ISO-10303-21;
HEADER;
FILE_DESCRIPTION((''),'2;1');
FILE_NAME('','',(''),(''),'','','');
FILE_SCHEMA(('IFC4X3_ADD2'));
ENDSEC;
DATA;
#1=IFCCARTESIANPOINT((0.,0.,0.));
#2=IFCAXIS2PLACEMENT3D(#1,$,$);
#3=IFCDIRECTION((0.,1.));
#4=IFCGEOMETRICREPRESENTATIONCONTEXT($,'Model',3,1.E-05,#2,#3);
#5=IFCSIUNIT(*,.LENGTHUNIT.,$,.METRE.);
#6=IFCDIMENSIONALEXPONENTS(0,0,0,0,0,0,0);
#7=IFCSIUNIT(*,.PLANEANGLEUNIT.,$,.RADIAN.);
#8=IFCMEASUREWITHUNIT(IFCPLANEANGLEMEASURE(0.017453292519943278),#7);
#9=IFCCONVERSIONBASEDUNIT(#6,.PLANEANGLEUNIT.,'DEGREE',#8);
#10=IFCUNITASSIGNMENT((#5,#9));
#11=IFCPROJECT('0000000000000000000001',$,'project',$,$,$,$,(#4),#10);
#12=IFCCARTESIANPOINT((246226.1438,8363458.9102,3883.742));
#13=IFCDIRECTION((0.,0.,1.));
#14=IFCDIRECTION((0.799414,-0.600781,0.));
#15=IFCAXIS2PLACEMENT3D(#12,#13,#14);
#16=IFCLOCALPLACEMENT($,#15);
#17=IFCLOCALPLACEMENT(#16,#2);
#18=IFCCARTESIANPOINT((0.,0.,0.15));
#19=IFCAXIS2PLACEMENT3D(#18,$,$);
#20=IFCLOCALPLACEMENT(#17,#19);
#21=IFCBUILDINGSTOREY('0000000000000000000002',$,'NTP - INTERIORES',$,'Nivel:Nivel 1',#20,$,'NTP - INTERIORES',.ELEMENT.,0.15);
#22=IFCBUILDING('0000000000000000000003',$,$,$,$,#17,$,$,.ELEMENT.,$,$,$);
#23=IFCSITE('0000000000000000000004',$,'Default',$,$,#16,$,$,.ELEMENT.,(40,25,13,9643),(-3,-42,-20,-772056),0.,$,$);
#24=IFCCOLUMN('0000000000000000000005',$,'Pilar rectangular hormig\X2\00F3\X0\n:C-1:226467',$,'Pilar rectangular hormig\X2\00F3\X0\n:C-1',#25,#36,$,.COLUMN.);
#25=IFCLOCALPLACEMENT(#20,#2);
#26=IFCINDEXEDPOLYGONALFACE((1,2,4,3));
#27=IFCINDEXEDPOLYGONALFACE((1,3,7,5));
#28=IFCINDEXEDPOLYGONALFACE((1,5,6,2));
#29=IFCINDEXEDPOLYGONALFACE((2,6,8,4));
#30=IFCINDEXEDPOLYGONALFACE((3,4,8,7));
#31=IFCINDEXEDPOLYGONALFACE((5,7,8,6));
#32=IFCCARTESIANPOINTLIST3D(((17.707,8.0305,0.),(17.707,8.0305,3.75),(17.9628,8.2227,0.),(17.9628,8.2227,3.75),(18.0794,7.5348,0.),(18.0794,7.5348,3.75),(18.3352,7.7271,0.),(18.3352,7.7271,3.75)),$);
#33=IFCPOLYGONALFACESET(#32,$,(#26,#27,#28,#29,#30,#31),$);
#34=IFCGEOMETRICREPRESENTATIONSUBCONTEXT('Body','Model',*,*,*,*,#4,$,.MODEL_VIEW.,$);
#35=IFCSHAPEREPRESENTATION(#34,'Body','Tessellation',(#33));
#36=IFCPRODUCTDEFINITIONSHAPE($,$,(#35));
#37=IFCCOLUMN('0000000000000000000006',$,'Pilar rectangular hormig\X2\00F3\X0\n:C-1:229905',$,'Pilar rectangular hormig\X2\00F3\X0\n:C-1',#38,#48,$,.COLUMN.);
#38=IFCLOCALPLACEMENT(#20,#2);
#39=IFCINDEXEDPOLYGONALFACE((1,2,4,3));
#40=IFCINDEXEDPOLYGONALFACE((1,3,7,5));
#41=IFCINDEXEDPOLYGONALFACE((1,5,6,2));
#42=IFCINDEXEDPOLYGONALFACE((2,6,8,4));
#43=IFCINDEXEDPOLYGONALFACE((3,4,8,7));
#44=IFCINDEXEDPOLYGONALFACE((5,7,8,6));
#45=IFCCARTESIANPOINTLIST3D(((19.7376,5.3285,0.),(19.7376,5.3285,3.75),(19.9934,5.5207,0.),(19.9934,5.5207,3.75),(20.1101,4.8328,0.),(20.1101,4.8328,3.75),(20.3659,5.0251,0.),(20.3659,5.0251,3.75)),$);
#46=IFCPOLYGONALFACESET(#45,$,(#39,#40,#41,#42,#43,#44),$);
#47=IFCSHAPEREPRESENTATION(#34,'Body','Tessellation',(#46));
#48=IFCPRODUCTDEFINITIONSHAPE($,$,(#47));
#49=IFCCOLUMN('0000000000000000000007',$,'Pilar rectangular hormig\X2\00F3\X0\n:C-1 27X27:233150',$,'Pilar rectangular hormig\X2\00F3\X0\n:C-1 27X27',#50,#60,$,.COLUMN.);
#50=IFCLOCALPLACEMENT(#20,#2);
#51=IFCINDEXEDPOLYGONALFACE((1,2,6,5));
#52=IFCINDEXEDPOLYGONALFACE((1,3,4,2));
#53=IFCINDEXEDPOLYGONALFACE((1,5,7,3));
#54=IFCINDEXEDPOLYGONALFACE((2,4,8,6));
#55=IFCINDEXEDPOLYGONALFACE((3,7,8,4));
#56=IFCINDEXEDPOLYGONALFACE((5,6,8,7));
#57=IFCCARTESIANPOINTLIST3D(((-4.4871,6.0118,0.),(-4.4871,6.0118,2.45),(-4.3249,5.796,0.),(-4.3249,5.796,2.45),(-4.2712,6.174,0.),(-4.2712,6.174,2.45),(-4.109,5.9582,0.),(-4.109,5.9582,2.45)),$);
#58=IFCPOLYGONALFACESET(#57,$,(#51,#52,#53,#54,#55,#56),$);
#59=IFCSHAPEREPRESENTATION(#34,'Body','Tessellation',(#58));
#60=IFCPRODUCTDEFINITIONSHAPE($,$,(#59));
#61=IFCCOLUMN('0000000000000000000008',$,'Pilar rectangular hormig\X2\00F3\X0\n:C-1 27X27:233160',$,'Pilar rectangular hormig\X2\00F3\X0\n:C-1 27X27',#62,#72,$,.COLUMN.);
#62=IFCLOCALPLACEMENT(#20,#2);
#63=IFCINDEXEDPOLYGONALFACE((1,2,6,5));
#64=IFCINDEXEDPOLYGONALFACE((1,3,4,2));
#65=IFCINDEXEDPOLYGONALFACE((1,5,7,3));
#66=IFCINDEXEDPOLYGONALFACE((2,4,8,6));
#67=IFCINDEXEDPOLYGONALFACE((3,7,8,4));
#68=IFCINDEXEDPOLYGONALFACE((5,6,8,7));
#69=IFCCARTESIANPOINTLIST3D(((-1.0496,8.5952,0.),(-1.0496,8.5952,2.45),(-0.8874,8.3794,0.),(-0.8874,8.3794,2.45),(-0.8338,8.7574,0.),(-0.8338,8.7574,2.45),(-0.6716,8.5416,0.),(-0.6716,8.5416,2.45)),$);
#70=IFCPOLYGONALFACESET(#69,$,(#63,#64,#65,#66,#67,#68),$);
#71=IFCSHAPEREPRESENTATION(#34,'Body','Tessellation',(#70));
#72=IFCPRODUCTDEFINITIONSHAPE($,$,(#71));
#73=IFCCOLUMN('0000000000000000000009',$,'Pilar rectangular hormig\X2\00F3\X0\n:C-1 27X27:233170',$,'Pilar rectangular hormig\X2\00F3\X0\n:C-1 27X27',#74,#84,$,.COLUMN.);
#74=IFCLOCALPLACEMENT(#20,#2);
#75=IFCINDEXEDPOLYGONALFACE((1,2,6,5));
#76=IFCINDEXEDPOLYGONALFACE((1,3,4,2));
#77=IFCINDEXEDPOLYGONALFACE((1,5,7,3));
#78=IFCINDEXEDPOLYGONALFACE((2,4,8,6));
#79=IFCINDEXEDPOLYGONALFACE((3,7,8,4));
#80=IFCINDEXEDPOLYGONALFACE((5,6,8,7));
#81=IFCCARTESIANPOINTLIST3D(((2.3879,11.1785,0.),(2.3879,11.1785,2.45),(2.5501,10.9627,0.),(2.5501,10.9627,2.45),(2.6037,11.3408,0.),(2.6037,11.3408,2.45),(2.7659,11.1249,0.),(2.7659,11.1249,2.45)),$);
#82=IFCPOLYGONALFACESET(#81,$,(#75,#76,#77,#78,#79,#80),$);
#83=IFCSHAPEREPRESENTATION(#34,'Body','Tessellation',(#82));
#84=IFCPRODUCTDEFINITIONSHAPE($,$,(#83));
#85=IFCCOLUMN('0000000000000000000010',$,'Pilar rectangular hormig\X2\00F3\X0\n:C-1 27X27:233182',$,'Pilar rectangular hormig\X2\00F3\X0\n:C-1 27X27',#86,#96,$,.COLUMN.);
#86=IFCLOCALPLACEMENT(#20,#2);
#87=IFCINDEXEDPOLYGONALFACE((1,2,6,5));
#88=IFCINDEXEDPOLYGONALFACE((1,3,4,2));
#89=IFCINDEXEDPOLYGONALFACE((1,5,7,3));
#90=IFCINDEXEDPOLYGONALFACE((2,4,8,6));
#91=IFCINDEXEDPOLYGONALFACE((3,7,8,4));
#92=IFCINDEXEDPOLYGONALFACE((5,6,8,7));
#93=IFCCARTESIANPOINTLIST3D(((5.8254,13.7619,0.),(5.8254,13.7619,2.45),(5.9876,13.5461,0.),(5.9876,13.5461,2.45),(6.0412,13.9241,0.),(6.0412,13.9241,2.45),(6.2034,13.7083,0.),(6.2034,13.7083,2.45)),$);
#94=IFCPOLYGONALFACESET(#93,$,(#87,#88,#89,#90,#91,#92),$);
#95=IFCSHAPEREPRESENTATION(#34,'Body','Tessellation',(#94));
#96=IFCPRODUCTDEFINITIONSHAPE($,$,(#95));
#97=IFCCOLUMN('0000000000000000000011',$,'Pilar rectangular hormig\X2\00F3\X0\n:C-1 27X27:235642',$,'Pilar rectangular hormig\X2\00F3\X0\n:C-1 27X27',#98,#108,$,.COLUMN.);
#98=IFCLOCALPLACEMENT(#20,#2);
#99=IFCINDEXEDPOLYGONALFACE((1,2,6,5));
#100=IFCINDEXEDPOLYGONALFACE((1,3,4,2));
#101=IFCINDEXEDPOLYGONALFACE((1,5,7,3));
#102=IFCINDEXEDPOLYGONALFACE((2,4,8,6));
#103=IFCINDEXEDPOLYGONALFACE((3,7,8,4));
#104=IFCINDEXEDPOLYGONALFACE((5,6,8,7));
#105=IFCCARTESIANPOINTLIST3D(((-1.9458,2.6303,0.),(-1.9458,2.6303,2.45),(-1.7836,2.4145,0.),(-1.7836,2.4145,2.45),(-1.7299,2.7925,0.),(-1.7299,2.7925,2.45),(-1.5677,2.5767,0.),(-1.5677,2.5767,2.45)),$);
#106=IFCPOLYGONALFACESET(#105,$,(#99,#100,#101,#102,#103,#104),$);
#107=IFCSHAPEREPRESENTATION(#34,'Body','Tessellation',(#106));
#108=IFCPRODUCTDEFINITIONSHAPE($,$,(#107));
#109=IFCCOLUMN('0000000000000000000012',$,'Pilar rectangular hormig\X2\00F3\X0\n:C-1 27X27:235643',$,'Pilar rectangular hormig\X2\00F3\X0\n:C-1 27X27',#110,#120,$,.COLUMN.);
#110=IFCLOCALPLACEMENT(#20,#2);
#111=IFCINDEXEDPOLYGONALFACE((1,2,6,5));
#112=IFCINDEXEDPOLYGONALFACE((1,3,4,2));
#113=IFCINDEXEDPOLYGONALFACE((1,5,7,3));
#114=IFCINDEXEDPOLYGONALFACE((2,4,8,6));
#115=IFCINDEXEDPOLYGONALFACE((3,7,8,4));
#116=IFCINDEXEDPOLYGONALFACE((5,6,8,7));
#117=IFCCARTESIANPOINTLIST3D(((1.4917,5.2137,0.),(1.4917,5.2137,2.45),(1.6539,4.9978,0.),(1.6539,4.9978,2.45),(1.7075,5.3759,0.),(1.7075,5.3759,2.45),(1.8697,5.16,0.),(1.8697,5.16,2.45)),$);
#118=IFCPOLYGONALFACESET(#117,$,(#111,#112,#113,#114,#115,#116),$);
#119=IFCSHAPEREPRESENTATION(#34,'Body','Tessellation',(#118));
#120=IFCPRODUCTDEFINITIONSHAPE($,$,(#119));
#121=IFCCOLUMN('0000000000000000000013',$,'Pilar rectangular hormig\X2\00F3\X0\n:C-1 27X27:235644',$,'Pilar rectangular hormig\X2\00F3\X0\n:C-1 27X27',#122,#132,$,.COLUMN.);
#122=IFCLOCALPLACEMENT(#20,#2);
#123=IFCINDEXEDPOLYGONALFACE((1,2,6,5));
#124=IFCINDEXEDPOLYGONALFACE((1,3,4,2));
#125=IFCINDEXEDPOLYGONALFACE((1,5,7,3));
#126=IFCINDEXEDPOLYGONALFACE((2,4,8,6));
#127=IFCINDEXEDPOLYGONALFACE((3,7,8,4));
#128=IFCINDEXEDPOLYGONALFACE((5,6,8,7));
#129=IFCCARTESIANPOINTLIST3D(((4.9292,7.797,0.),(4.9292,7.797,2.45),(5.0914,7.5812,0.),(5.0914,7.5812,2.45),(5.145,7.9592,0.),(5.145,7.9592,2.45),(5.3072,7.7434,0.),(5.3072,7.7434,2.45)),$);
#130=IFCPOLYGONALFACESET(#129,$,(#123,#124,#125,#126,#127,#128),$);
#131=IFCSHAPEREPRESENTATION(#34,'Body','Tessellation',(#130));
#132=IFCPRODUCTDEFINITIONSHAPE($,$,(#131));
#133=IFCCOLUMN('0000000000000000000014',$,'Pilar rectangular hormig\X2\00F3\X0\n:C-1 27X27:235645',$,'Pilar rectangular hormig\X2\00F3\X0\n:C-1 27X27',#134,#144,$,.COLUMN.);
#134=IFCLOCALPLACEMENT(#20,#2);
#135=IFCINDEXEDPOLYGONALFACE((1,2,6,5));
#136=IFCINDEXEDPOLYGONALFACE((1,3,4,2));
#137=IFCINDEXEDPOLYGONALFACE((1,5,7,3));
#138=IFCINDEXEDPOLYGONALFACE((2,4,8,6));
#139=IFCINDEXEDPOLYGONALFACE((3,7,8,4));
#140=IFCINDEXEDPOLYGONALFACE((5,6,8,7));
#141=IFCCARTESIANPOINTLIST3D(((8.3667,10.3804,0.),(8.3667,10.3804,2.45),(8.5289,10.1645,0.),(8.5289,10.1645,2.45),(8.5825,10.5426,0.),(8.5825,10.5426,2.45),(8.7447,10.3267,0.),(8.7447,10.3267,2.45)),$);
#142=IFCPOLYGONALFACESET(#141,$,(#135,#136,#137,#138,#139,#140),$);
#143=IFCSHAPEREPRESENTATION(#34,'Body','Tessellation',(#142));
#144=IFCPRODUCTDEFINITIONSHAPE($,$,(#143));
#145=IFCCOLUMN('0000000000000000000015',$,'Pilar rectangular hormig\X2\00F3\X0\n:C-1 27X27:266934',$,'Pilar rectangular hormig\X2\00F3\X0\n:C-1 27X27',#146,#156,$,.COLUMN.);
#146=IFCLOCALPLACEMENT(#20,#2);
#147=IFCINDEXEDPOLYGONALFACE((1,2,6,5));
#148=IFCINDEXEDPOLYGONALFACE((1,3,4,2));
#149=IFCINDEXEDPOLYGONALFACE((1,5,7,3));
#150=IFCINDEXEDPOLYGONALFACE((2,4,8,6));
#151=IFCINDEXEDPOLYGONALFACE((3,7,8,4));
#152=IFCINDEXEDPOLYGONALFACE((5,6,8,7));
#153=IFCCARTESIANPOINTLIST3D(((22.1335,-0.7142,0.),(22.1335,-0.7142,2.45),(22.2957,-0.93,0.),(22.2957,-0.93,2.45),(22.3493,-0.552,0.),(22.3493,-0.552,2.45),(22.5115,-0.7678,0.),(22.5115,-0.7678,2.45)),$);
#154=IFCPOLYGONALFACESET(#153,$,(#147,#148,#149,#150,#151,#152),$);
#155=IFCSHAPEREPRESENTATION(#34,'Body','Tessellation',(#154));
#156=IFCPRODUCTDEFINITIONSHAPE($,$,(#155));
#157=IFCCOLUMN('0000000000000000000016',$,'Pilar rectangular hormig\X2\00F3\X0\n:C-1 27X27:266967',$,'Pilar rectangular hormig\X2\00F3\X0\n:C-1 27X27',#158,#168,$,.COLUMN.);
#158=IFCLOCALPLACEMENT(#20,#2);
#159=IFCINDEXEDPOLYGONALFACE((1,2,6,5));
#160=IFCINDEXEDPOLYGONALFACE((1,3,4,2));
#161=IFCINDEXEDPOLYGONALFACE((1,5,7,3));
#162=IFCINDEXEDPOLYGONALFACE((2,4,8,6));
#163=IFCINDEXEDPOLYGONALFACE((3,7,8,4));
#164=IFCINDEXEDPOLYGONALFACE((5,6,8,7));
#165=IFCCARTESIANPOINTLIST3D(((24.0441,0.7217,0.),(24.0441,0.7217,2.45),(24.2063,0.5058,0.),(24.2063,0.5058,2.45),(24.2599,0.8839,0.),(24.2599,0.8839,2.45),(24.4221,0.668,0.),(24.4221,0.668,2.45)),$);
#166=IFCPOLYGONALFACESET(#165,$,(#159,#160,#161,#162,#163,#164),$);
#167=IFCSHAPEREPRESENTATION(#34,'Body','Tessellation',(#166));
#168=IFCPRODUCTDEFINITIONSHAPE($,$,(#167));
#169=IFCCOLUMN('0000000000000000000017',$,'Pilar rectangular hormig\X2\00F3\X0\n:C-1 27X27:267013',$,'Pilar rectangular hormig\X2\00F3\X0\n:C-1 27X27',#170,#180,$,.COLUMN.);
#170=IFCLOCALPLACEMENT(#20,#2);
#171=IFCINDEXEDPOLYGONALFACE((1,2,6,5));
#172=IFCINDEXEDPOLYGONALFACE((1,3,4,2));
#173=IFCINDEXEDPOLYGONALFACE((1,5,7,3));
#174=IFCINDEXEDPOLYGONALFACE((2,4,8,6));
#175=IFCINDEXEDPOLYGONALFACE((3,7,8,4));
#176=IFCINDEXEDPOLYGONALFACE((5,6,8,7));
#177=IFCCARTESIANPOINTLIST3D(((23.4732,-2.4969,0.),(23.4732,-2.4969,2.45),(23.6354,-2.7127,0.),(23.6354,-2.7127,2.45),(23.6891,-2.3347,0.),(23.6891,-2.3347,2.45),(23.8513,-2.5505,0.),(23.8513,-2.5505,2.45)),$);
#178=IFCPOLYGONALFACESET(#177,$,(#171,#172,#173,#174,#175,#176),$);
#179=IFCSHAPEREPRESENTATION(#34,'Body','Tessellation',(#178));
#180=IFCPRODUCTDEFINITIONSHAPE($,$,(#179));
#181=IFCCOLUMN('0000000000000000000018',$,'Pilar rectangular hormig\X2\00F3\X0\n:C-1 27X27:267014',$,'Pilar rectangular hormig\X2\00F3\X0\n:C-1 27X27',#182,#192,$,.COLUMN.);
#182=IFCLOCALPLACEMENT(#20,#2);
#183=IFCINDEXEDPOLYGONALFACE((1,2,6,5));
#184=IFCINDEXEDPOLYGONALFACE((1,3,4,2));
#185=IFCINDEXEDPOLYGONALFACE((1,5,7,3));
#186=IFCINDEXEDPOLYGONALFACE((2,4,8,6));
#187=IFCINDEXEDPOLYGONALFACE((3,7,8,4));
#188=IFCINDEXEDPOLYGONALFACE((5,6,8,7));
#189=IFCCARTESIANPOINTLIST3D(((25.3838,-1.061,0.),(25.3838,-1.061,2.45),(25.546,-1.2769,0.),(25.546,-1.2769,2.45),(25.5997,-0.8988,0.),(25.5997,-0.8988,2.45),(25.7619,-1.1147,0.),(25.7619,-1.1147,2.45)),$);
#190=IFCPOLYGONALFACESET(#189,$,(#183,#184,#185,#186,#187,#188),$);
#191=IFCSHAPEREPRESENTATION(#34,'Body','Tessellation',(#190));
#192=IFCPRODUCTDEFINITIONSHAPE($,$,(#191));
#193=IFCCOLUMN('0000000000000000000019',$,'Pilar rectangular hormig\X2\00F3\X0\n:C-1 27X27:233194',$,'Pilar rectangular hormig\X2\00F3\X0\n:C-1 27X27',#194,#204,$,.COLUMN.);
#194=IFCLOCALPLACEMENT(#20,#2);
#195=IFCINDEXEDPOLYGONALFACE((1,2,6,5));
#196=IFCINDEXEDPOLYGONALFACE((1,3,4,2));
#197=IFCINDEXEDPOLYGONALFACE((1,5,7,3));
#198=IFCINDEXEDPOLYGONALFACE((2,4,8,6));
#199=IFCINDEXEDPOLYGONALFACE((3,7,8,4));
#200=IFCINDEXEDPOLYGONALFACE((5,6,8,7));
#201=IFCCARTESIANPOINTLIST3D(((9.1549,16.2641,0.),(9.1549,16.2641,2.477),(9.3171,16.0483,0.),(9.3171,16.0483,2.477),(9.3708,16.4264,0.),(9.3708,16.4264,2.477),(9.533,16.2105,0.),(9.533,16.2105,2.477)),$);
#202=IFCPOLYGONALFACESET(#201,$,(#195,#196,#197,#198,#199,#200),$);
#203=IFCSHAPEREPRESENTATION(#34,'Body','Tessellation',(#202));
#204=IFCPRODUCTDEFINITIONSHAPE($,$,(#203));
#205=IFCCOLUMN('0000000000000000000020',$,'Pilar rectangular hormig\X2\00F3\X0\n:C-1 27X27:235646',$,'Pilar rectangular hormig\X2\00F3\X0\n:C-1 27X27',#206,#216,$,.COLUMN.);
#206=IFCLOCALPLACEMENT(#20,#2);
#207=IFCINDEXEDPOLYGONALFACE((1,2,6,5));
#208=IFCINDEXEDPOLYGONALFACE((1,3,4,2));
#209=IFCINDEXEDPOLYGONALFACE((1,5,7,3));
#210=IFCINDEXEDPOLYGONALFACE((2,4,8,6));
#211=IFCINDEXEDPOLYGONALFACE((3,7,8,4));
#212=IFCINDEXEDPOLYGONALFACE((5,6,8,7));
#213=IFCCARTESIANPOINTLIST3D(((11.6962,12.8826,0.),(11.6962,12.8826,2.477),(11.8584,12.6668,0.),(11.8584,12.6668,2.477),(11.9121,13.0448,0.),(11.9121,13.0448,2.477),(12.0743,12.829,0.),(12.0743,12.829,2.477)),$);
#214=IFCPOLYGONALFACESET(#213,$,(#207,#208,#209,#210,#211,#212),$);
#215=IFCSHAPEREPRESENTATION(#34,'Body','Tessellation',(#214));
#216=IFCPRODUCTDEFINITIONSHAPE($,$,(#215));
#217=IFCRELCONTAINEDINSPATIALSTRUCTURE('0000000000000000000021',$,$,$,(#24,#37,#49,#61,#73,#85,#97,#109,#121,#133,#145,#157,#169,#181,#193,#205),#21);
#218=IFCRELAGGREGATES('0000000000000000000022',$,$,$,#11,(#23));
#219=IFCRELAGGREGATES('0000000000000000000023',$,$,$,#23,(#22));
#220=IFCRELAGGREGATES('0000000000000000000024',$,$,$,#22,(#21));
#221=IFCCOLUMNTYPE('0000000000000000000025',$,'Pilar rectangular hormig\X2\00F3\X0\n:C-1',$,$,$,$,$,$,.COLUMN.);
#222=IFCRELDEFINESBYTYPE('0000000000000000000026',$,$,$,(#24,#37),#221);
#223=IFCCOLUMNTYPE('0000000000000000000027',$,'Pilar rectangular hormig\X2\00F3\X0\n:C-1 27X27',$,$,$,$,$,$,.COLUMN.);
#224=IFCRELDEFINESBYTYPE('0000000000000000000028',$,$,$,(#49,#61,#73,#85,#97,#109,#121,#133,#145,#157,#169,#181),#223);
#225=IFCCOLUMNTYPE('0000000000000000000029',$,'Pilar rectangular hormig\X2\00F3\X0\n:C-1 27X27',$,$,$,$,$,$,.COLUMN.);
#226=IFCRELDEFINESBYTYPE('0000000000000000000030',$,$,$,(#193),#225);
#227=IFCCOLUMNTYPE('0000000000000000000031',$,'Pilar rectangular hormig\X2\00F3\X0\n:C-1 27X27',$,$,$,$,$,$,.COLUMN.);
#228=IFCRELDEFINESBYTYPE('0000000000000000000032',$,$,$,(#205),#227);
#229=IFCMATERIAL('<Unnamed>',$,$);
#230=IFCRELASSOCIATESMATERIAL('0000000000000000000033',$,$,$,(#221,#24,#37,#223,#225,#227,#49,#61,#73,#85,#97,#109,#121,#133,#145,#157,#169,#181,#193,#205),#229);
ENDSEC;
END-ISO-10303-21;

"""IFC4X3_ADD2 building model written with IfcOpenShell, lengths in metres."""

from ifc_helpers import new_model, entity, si_unit, converted_unit, direction, frame, frame_2d, origin, origin_2d_with_axis, place, context, subcontext, project, spatial, rectangle, extrude, source, transform, mapped, material, material_profile, profile_set, profile_usage, type_object, type_shapes, element, save


model = new_model("IFC4X3_ADD2")

# Units and contexts
model_context = context("Model", 3, precision=1e-05, world=origin(), true_north=direction((0.0, 1.0)))
body_context = subcontext(model_context, "Body", "Model", "MODEL_VIEW")
ifc_project = project(units=[si_unit("LENGTHUNIT", "METRE"), converted_unit("PLANEANGLEUNIT", "DEGREE", entity("IfcPlaneAngleMeasure", 0.017453292519943278), si_unit("PLANEANGLEUNIT", "RADIAN"), dimensions=[0, 0, 0, 0, 0, 0, 0])], contexts=[model_context])

# Site, building, storey
site_placement = place(None, frame((246226.1438, 8363458.9102, 3883.742), z_axis=(0.0, 0.0, 1.0), x_axis=(0.799414, -0.600781, 0.0)))
site = spatial("IfcSite", under=ifc_project, at=site_placement, Name="Default", CompositionType="ELEMENT", RefLatitude=(40, 25, 13, 9643), RefLongitude=(-3, -42, -20, -772056), RefElevation=0.0)
building_placement = place(site_placement, origin())
building = spatial("IfcBuilding", under=site, at=building_placement, CompositionType="ELEMENT")
storey_placement = place(building_placement, frame((0.0, 0.0, 0.15)))
storey = spatial("IfcBuildingStorey", under=building, at=storey_placement, Name="NTP - INTERIORES", ObjectType="Nivel:Nivel 1", LongName="NTP - INTERIORES", CompositionType="ELEMENT", Elevation=0.15)

# Columns
ifc_material_1 = material(Name="<Unnamed>")
ifc_material_profile_1 = material_profile(ifc_material_1, rectangle(XDim=0.32, YDim=0.62, at=origin_2d_with_axis()), Name="C-1")
ifc_profile_set_1 = profile_set([ifc_material_profile_1], Name="C-1")
ifc_profile_usage_1 = profile_usage(ifc_profile_set_1)
column_type_1 = type_object("IfcColumnType", Name="Pilar rectangular hormigón:C-1", PredefinedType="COLUMN", material=ifc_profile_set_1)
shared_shape_1 = source(origin(), body_context, "Body", "SweptSolid", [
    extrude(rectangle(XDim=0.32, YDim=0.62, at=origin_2d_with_axis()), frame((0.16, 0.31, 0.0), z_axis=(0.0, 0.0, 1.0), x_axis=(-1.0, 0.0, 0.0)), (0.0, 0.0, 1.0), 3.75),
])
type_shapes(column_type_1, [shared_shape_1])
for number, where, z_axis, x_axis, name in (
    (1, (18.0794, 7.5348, 0.0), (0.0, 0.0, 1.0), (0.799414, 0.60078, 0.0), "Pilar rectangular hormigón:C-1:226467"),
    (2, (20.1101, 4.8328, 0.0), (0.0, 0.0, 1.0), (0.799414, 0.60078, 0.0), "Pilar rectangular hormigón:C-1:229905"),
):
    element("IfcColumn", number, at=place(storey_placement, frame(where, z_axis=z_axis, x_axis=x_axis)), inside=storey, type_object=column_type_1, material=ifc_profile_usage_1, Name=name, ObjectType="Pilar rectangular hormigón:C-1", PredefinedType="COLUMN", context=body_context, shape_type="MappedRepresentation", body=[
        mapped(shared_shape_1, transform((0.0, 0.0, 0.0), scale=1.0)),
    ])
ifc_material_profile_2 = material_profile(ifc_material_1, rectangle(XDim=0.27, YDim=0.27, at=origin_2d_with_axis()), Name="C-1 27X27")
ifc_profile_set_2 = profile_set([ifc_material_profile_2], Name="C-1 27X27")
ifc_profile_usage_2 = profile_usage(ifc_profile_set_2)
column_type_2 = type_object("IfcColumnType", Name="Pilar rectangular hormigón:C-1 27X27", PredefinedType="COLUMN", material=ifc_profile_set_2)
shared_shape_2 = source(origin(), body_context, "Body", "SweptSolid", [
    extrude(rectangle(XDim=0.27, YDim=0.27, at=origin_2d_with_axis()), frame((0.135, 0.135, 0.0), z_axis=(0.0, 0.0, 1.0), x_axis=(-1.0, 0.0, 0.0)), (0.0, 0.0, 1.0), 2.45),
])
type_shapes(column_type_2, [shared_shape_2])
for number, where, z_axis, x_axis, name in (
    (3, (-4.3249, 5.796, 0.0), (0.0, 0.0, 1.0), (0.799414, 0.60078, 0.0), "Pilar rectangular hormigón:C-1 27X27:233150"),
    (4, (-0.8874, 8.3794, 0.0), (0.0, 0.0, 1.0), (0.799414, 0.60078, 0.0), "Pilar rectangular hormigón:C-1 27X27:233160"),
    (5, (2.5501, 10.9627, 0.0), (0.0, 0.0, 1.0), (0.799414, 0.60078, 0.0), "Pilar rectangular hormigón:C-1 27X27:233170"),
    (6, (5.9876, 13.5461, 0.0), (0.0, 0.0, 1.0), (0.799414, 0.60078, 0.0), "Pilar rectangular hormigón:C-1 27X27:233182"),
    (7, (-1.7836, 2.4145, 0.0), (0.0, 0.0, 1.0), (0.799414, 0.60078, 0.0), "Pilar rectangular hormigón:C-1 27X27:235642"),
    (8, (1.6539, 4.9978, 0.0), (0.0, 0.0, 1.0), (0.799414, 0.60078, 0.0), "Pilar rectangular hormigón:C-1 27X27:235643"),
    (9, (5.0914, 7.5812, 0.0), (0.0, 0.0, 1.0), (0.799414, 0.60078, 0.0), "Pilar rectangular hormigón:C-1 27X27:235644"),
    (10, (8.5289, 10.1645, 0.0), (0.0, 0.0, 1.0), (0.799414, 0.60078, 0.0), "Pilar rectangular hormigón:C-1 27X27:235645"),
    (11, (22.2957, -0.93, 0.0), (0.0, 0.0, 1.0), (0.799414, 0.60078, 0.0), "Pilar rectangular hormigón:C-1 27X27:266934"),
    (12, (24.2063, 0.5058, 0.0), (0.0, 0.0, 1.0), (0.799414, 0.60078, 0.0), "Pilar rectangular hormigón:C-1 27X27:266967"),
    (13, (23.6354, -2.7127, 0.0), (0.0, 0.0, 1.0), (0.799414, 0.60078, 0.0), "Pilar rectangular hormigón:C-1 27X27:267013"),
    (14, (25.546, -1.2769, 0.0), (0.0, 0.0, 1.0), (0.799414, 0.60078, 0.0), "Pilar rectangular hormigón:C-1 27X27:267014"),
):
    element("IfcColumn", number, at=place(storey_placement, frame(where, z_axis=z_axis, x_axis=x_axis)), inside=storey, type_object=column_type_2, material=ifc_profile_usage_2, Name=name, ObjectType="Pilar rectangular hormigón:C-1 27X27", PredefinedType="COLUMN", context=body_context, shape_type="MappedRepresentation", body=[
        mapped(shared_shape_2, transform((0.0, 0.0, 0.0), scale=1.0)),
    ])
column_type_3 = type_object("IfcColumnType", Name="Pilar rectangular hormigón:C-1 27X27", PredefinedType="COLUMN", material=ifc_profile_set_2)
shared_shape_3 = source(origin(), body_context, "Body", "SweptSolid", [
    extrude(rectangle(XDim=0.27, YDim=0.27, at=frame_2d((0.0, 0.0), x_axis=(1.0, 0.0))), frame((9.3439, 16.2373, 0.15), z_axis=(0.0, 0.0, 1.0), x_axis=(-0.799414, -0.60078, 0.0)), (0.0, 0.0, 1.0), 2.477),
])
type_shapes(column_type_3, [shared_shape_3])
column_1_placement = place(storey_placement, frame((0.0, 0.0, -0.15)))
element("IfcColumn", 15, at=column_1_placement, inside=storey, type_object=column_type_3, material=ifc_profile_usage_2, Name="Pilar rectangular hormigón:C-1 27X27:233194", ObjectType="Pilar rectangular hormigón:C-1 27X27", PredefinedType="COLUMN", context=body_context, shape_type="MappedRepresentation", body=[
    mapped(shared_shape_3, transform((0.0, 0.0, 0.0), scale=1.0)),
])
column_type_4 = type_object("IfcColumnType", Name="Pilar rectangular hormigón:C-1 27X27", PredefinedType="COLUMN", material=ifc_profile_set_2)
shared_shape_4 = source(origin(), body_context, "Body", "SweptSolid", [
    extrude(rectangle(XDim=0.27, YDim=0.27, at=frame_2d((0.0, 0.0), x_axis=(1.0, 0.0))), frame((11.8852, 12.8558, 0.15), z_axis=(0.0, 0.0, 1.0), x_axis=(-0.799414, -0.60078, 0.0)), (0.0, 0.0, 1.0), 2.477),
])
type_shapes(column_type_4, [shared_shape_4])
column_2_placement = place(storey_placement, frame((0.0, 0.0, -0.15)))
element("IfcColumn", 16, at=column_2_placement, inside=storey, type_object=column_type_4, material=ifc_profile_usage_2, Name="Pilar rectangular hormigón:C-1 27X27:235646", ObjectType="Pilar rectangular hormigón:C-1 27X27", PredefinedType="COLUMN", context=body_context, shape_type="MappedRepresentation", body=[
    mapped(shared_shape_4, transform((0.0, 0.0, 0.0), scale=1.0)),
])

save(model, "model.ifc")
